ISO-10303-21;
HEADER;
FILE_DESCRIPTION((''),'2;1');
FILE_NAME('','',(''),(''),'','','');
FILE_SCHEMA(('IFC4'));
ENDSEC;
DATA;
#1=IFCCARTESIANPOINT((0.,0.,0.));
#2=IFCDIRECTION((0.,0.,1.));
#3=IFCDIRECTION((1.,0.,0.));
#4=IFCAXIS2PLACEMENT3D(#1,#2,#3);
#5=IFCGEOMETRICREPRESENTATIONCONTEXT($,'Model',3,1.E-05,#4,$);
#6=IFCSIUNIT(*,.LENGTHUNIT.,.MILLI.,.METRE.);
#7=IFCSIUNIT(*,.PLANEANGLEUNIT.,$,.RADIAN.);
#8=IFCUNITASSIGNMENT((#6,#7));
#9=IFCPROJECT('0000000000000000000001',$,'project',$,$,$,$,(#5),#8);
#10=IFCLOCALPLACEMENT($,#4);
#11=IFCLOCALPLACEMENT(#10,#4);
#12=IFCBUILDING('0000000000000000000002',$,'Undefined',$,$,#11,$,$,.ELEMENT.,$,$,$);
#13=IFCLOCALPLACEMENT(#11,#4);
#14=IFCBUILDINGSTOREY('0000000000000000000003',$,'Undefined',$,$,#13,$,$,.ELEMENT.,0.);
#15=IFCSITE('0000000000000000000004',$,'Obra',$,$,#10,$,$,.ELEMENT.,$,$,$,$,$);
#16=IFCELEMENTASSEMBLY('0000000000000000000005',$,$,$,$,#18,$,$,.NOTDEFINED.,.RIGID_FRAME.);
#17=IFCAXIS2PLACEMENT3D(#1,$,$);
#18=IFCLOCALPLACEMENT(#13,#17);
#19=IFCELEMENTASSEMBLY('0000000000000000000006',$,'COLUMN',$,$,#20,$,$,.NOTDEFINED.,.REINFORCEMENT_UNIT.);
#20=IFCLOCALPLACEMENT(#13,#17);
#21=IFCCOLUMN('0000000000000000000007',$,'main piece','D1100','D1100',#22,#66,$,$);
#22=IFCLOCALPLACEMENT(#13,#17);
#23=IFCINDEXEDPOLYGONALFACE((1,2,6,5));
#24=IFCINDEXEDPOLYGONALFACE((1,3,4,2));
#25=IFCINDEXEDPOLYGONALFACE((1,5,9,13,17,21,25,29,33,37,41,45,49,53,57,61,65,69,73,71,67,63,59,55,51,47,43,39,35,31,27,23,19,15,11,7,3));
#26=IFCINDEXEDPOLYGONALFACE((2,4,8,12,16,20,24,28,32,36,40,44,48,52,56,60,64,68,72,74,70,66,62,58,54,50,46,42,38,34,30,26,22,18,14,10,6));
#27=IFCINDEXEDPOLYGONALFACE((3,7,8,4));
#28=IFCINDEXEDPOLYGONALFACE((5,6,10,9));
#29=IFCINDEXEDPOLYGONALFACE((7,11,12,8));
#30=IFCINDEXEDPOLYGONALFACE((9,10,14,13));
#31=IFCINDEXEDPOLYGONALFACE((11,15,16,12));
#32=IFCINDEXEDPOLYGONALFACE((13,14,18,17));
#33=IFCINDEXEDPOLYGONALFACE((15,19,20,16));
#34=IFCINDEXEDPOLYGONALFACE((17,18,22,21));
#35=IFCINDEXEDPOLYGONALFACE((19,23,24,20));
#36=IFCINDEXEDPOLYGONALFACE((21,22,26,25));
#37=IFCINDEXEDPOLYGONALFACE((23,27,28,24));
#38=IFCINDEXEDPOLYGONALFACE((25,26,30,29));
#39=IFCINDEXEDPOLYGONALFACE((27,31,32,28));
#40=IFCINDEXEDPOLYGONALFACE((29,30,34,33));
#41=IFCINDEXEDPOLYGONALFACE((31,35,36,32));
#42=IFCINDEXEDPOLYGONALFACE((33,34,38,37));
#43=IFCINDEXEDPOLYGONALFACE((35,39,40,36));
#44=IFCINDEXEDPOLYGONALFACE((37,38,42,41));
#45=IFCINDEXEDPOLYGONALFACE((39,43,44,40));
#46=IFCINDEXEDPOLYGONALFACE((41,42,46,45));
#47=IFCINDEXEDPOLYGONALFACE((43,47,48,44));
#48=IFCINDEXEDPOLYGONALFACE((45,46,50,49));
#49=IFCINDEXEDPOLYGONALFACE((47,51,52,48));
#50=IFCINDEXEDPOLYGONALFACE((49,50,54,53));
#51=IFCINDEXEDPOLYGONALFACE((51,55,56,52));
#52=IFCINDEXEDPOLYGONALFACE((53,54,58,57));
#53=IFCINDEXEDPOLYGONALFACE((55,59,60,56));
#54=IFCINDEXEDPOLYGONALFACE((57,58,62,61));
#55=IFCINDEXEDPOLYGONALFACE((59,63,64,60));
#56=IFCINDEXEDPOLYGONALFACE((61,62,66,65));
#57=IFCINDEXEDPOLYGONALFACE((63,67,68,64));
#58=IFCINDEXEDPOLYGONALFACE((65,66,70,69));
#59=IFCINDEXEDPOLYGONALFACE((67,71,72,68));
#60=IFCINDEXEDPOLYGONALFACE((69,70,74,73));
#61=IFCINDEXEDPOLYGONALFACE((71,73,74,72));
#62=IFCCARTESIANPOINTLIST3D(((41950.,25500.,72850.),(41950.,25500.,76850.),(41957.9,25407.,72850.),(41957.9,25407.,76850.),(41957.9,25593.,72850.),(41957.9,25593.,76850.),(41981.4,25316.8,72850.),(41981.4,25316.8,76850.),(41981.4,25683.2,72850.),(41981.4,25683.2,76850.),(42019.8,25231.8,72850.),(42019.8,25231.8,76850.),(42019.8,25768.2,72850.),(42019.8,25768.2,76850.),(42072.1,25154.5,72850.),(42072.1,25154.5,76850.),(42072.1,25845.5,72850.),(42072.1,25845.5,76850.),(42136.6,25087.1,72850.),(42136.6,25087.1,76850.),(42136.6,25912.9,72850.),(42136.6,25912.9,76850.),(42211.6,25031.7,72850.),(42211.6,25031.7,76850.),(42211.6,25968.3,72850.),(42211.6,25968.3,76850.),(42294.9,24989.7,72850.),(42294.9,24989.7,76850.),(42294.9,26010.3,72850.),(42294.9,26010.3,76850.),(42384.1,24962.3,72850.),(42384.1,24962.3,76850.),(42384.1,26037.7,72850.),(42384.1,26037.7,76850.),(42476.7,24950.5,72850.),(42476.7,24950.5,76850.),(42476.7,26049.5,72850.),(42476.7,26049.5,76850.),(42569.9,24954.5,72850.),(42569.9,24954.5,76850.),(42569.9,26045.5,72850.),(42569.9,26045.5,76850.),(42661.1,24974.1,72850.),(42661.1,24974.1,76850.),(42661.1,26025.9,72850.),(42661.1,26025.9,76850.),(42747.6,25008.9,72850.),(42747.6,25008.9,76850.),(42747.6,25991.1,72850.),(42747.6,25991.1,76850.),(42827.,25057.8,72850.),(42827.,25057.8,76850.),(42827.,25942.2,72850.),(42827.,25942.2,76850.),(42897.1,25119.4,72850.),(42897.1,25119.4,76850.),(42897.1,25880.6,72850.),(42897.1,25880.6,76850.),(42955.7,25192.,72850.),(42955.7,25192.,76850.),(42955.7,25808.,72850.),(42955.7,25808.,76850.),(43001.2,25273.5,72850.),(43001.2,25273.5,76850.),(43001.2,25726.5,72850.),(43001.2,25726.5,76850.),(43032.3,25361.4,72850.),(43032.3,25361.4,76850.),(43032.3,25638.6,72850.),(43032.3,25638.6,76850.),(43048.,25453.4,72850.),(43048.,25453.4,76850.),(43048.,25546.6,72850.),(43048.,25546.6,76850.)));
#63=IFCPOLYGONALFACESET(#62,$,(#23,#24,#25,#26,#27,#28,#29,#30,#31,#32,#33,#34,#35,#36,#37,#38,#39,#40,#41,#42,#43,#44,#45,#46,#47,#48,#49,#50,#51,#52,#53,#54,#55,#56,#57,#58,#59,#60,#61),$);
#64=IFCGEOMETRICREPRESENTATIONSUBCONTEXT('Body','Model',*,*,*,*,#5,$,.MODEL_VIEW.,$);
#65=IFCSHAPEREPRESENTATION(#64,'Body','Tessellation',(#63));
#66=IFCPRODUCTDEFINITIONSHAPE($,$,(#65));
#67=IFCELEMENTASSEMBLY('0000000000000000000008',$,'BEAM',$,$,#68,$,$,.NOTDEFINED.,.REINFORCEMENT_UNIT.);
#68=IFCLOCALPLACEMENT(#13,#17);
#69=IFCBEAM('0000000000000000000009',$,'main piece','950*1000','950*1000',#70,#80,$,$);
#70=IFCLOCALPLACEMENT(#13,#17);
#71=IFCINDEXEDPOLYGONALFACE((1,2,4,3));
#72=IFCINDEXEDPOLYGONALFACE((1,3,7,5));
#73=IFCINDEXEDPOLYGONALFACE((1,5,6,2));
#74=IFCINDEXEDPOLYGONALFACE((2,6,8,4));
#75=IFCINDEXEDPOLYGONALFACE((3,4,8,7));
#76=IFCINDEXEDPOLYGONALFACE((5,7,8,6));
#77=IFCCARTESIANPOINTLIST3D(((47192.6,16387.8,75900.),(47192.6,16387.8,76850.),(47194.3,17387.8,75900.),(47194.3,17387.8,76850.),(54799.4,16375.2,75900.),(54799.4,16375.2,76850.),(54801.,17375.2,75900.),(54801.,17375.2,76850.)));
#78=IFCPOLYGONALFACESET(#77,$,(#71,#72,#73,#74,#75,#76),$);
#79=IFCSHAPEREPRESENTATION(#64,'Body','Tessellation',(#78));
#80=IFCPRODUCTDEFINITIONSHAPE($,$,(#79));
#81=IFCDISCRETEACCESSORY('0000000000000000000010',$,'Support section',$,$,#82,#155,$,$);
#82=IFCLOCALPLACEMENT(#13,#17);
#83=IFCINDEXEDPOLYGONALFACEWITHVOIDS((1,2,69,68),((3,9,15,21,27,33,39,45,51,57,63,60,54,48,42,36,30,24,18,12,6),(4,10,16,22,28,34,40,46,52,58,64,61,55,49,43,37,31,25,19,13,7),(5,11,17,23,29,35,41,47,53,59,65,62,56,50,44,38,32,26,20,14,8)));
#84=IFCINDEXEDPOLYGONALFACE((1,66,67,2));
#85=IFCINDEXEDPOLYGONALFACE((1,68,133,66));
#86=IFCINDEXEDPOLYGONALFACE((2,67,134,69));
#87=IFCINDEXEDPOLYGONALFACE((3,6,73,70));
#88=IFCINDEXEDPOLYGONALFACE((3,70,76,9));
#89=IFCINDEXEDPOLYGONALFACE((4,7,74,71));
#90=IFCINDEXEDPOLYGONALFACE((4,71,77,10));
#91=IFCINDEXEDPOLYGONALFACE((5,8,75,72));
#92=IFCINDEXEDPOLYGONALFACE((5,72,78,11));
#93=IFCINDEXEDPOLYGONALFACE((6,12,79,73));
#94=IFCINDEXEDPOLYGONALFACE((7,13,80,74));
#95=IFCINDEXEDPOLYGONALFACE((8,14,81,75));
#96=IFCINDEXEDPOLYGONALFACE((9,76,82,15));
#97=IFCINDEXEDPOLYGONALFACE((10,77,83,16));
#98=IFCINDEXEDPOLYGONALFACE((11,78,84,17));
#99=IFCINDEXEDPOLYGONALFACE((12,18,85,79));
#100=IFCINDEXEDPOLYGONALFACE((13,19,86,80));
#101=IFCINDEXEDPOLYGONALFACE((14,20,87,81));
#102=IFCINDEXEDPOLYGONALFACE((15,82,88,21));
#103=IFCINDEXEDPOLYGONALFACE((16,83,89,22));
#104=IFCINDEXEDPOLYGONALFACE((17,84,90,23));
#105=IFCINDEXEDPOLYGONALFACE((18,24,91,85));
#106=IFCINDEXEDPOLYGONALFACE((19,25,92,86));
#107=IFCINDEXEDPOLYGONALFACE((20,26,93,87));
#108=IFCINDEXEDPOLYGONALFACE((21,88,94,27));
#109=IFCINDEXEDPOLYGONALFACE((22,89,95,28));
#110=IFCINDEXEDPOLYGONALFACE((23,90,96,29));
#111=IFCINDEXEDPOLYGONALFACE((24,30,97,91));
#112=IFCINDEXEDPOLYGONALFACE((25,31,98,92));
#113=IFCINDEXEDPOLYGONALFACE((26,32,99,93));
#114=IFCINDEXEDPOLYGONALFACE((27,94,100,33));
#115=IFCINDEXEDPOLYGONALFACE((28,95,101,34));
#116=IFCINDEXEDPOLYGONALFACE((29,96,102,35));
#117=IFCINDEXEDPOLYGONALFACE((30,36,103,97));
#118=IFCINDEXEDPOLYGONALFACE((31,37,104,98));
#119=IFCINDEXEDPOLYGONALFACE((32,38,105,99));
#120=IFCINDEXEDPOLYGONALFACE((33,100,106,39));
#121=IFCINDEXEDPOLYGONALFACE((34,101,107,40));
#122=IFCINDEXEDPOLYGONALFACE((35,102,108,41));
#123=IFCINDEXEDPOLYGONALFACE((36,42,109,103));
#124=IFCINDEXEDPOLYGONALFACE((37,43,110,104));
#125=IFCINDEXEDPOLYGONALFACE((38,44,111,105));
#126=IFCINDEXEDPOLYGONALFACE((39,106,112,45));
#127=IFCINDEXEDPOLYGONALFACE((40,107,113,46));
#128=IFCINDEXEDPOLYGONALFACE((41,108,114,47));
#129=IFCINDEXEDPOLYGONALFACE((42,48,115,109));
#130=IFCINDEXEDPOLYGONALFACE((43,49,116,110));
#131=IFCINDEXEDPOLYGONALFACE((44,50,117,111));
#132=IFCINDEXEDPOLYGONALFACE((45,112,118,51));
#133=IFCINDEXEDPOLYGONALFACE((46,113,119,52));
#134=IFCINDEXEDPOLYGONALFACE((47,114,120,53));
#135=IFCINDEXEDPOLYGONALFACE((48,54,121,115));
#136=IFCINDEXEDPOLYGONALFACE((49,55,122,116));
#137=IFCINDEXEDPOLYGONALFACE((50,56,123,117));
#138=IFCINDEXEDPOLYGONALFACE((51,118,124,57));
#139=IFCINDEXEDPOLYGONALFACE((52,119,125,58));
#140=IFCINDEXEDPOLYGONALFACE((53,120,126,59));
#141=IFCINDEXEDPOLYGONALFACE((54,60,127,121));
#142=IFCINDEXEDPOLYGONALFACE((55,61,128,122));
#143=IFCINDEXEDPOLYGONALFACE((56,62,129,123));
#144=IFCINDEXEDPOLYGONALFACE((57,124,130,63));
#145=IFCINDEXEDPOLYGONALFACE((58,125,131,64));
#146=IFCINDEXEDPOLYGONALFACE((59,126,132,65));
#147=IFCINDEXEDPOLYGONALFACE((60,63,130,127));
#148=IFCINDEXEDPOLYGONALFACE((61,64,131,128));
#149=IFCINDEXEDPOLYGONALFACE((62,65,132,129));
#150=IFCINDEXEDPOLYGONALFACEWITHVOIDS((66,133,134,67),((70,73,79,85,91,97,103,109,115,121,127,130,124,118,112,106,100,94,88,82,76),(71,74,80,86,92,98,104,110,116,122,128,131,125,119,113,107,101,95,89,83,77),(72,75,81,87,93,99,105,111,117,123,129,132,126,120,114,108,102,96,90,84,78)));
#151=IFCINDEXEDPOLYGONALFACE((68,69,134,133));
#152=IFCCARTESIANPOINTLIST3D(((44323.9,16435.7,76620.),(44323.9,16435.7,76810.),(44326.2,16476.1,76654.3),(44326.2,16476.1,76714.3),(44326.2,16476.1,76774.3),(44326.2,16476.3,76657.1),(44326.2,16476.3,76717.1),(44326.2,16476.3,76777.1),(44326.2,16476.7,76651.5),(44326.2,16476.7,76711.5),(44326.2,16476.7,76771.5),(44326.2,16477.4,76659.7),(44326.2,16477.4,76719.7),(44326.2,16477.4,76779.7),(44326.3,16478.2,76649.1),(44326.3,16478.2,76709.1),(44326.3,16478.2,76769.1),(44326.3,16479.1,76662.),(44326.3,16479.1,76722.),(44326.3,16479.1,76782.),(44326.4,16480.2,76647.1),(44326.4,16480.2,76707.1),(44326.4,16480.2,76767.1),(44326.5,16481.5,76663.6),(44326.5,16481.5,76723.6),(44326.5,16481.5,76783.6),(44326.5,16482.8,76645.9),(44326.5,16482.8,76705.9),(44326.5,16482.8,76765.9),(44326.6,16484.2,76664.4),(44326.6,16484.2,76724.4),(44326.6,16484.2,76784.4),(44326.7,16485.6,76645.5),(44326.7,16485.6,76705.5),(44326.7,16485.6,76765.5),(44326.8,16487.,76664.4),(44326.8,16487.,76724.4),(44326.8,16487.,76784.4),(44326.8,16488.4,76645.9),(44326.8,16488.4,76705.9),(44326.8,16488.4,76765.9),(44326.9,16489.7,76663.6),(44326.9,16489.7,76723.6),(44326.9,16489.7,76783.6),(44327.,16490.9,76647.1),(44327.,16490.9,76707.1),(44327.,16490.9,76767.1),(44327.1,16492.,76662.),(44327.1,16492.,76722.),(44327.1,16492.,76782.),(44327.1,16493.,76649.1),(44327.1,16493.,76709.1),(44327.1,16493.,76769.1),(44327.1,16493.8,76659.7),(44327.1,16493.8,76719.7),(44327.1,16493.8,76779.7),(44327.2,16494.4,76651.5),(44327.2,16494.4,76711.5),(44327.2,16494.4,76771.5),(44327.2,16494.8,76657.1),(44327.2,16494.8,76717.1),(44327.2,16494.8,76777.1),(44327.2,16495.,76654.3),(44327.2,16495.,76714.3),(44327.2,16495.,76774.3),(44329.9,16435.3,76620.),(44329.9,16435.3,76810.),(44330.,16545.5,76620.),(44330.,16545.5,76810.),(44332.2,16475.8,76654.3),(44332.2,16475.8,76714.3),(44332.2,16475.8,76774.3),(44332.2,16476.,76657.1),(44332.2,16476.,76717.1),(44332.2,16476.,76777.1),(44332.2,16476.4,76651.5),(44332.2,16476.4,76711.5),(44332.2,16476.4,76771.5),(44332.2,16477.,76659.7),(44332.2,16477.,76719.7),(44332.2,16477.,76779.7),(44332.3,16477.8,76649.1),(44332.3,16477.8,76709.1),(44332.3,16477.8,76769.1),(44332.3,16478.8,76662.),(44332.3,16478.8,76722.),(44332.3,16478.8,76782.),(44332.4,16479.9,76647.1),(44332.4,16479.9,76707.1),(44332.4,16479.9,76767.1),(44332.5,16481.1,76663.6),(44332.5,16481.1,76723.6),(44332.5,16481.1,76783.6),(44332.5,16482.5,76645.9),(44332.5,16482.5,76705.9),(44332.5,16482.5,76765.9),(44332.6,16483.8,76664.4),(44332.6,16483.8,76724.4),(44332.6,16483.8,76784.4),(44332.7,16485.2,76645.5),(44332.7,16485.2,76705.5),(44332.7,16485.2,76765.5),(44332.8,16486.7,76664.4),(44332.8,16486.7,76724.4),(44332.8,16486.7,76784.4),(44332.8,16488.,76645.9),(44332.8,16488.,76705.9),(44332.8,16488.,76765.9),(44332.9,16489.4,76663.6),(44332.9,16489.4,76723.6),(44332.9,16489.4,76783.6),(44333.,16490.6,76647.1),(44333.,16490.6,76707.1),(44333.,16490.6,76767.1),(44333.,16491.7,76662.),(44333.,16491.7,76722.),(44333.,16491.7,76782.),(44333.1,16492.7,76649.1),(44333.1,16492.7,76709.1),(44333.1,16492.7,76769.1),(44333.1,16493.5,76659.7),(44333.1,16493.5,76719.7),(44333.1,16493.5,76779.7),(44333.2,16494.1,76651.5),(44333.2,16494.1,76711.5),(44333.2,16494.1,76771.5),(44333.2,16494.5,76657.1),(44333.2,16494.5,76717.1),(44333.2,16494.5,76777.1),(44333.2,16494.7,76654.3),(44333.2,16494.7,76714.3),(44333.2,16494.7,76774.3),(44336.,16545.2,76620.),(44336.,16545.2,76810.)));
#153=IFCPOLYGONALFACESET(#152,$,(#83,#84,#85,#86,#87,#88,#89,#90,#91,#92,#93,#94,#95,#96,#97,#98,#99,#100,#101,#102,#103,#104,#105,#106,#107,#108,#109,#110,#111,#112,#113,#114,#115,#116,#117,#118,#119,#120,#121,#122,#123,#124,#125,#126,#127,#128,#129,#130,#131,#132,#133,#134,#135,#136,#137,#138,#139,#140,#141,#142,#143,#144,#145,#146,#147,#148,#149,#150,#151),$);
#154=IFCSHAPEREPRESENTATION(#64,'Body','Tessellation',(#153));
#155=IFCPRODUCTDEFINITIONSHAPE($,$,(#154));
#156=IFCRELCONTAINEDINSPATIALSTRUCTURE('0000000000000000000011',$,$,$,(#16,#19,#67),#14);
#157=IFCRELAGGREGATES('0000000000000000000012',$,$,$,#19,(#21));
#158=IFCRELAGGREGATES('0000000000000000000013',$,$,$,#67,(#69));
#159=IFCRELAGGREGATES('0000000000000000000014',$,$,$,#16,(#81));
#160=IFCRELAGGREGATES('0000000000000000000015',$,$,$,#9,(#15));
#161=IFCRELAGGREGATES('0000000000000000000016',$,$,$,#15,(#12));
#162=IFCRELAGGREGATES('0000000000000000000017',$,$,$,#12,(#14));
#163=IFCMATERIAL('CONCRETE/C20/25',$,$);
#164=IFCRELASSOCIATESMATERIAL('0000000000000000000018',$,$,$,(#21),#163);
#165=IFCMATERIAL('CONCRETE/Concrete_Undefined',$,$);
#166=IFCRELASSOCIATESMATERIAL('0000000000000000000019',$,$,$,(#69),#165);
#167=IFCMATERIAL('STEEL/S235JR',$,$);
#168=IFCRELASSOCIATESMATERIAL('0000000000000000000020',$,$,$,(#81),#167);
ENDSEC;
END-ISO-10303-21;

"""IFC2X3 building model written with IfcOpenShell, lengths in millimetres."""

from ifc_helpers import new_model, si_unit, frame, origin_with_axes, origin_2d_with_axis, place, context, subcontext, project, spatial, rectangle, circle, extrude, source, transform, mapped, material, element, aggregate, save


model = new_model("IFC2X3")

# Units and contexts
model_context = context("Model", 3, precision=1e-05, world=origin_with_axes())
body_context = subcontext(model_context, "Body", "Model", "MODEL_VIEW")
ifc_project = project(units=[si_unit("LENGTHUNIT", "METRE", prefix="MILLI"), si_unit("PLANEANGLEUNIT", "RADIAN")], contexts=[model_context])

# Site, building, storey
site_placement = place(None, origin_with_axes())
site = spatial("IfcSite", under=ifc_project, at=site_placement, Name="Obra", CompositionType="ELEMENT")
building_placement = place(site_placement, origin_with_axes())
building = spatial("IfcBuilding", under=site, at=building_placement, Name="Undefined", CompositionType="ELEMENT")
storey_placement = place(building_placement, origin_with_axes())
storey = spatial("IfcBuildingStorey", under=building, at=storey_placement, Name="Undefined", CompositionType="ELEMENT", Elevation=0.0)

# Element assemblies, column
assembly_1_placement = place(storey_placement, origin_with_axes())
assembly_1 = element("IfcElementAssembly", 1, at=assembly_1_placement, inside=storey, AssemblyPlace="NOTDEFINED", PredefinedType="RIGID_FRAME")
ifc_material_1 = material(Name="STEEL/S235JR")
assembly_2_placement = place(storey_placement, origin_with_axes())
assembly_2 = element("IfcElementAssembly", 2, at=assembly_2_placement, inside=storey, Name="COLUMN", AssemblyPlace="NOTDEFINED", PredefinedType="REINFORCEMENT_UNIT")
ifc_material_2 = material(Name="CONCRETE/C20/25")
column_1_placement = place(assembly_2_placement, frame((42500.0, 25500.0, 72850.0), z_axis=(0.0, 0.0, 1.0), x_axis=(0.0, 1.0, 0.0)))
column_1 = element("IfcColumn", 3, at=column_1_placement, material=ifc_material_2, Name="main piece", Description="D1100", ObjectType="D1100", context=body_context, shape_type="SweptSolid", body=[
    extrude(circle(Radius=550.0, at=origin_2d_with_axis()), frame((0.0, 0.0, 4000.0), z_axis=(0.0, 0.0, -1.0), x_axis=(0.0, 1.0, 0.0)), (0.0, 0.0, 1.0), 4000.0),
])
aggregate(assembly_2, [column_1])

# Element assembly, beam
assembly_3_placement = place(storey_placement, origin_with_axes())
assembly_3 = element("IfcElementAssembly", 4, at=assembly_3_placement, inside=storey, Name="BEAM", AssemblyPlace="NOTDEFINED", PredefinedType="REINFORCEMENT_UNIT")
ifc_material_3 = material(Name="CONCRETE/Concrete_Undefined")
beam_placement = place(assembly_3_placement, frame((47193.5, 16887.8, 76375.0), z_axis=(0.0, 0.0, 1.0), x_axis=(0.999999, -0.001649, 0.0)))
beam = element("IfcBeam", 5, at=beam_placement, material=ifc_material_3, Name="main piece", Description="950*1000", ObjectType="950*1000", context=body_context, shape_type="SweptSolid", body=[
    extrude(rectangle(XDim=1000.0, YDim=950.0, at=origin_2d_with_axis()), frame((7606.8, 0.0, 0.0), z_axis=(-1.0, 0.0, 0.0), x_axis=(0.0, -1.0, 0.0)), (0.0, 0.0, 1.0), 7606.8),
])
aggregate(assembly_3, [beam])

# Discrete accessory, opening
discrete_accessory_1_placement = place(assembly_1_placement, frame((44330.0, 16490.4, 76620.0), z_axis=(0.0, 0.0, 1.0), x_axis=(0.055268, 0.998472, 0.0)))
discrete_accessory_1 = element("IfcDiscreteAccessory", 6, at=discrete_accessory_1_placement, material=ifc_material_1, Name="Support section", context=body_context, shape_type="SweptSolid", body=[
    extrude(rectangle(XDim=6.0, YDim=110.0, at=origin_2d_with_axis()), frame((0.0, 0.0, 190.0), z_axis=(0.0, 0.0, -1.0), x_axis=(0.0, 1.0, 0.0)), (0.0, 0.0, 1.0), 190.0),
])
shared_shape = source(origin_with_axes(), body_context, "Body", "SweptSolid", [
    extrude(circle(Radius=9.5, at=origin_2d_with_axis()), frame((0.0, -9.2, 0.0), z_axis=(0.0, 1.0, 0.0), x_axis=(1.0, 0.0, 0.0)), (0.0, 0.0, 1.0), 6.2),
])
opening_1_placement = place(assembly_1_placement, frame((44338.5, 16535.0, 76835.0), z_axis=(-0.055268, -0.998472, 0.0), x_axis=(0.0, 0.0, -1.0)))
element("IfcOpeningElement", 7, at=opening_1_placement, cuts=discrete_accessory_1, ObjectType="Opening", context=body_context, shape_type="MappedRepresentation", body=[
    mapped(shared_shape, transform((60.0, 0.0, 50.0))),
    mapped(shared_shape, transform((120.0, 0.0, 50.0))),
    mapped(shared_shape, transform((180.0, 0.0, 50.0))),
])
aggregate(assembly_1, [discrete_accessory_1])

save(model, "model.ifc")
